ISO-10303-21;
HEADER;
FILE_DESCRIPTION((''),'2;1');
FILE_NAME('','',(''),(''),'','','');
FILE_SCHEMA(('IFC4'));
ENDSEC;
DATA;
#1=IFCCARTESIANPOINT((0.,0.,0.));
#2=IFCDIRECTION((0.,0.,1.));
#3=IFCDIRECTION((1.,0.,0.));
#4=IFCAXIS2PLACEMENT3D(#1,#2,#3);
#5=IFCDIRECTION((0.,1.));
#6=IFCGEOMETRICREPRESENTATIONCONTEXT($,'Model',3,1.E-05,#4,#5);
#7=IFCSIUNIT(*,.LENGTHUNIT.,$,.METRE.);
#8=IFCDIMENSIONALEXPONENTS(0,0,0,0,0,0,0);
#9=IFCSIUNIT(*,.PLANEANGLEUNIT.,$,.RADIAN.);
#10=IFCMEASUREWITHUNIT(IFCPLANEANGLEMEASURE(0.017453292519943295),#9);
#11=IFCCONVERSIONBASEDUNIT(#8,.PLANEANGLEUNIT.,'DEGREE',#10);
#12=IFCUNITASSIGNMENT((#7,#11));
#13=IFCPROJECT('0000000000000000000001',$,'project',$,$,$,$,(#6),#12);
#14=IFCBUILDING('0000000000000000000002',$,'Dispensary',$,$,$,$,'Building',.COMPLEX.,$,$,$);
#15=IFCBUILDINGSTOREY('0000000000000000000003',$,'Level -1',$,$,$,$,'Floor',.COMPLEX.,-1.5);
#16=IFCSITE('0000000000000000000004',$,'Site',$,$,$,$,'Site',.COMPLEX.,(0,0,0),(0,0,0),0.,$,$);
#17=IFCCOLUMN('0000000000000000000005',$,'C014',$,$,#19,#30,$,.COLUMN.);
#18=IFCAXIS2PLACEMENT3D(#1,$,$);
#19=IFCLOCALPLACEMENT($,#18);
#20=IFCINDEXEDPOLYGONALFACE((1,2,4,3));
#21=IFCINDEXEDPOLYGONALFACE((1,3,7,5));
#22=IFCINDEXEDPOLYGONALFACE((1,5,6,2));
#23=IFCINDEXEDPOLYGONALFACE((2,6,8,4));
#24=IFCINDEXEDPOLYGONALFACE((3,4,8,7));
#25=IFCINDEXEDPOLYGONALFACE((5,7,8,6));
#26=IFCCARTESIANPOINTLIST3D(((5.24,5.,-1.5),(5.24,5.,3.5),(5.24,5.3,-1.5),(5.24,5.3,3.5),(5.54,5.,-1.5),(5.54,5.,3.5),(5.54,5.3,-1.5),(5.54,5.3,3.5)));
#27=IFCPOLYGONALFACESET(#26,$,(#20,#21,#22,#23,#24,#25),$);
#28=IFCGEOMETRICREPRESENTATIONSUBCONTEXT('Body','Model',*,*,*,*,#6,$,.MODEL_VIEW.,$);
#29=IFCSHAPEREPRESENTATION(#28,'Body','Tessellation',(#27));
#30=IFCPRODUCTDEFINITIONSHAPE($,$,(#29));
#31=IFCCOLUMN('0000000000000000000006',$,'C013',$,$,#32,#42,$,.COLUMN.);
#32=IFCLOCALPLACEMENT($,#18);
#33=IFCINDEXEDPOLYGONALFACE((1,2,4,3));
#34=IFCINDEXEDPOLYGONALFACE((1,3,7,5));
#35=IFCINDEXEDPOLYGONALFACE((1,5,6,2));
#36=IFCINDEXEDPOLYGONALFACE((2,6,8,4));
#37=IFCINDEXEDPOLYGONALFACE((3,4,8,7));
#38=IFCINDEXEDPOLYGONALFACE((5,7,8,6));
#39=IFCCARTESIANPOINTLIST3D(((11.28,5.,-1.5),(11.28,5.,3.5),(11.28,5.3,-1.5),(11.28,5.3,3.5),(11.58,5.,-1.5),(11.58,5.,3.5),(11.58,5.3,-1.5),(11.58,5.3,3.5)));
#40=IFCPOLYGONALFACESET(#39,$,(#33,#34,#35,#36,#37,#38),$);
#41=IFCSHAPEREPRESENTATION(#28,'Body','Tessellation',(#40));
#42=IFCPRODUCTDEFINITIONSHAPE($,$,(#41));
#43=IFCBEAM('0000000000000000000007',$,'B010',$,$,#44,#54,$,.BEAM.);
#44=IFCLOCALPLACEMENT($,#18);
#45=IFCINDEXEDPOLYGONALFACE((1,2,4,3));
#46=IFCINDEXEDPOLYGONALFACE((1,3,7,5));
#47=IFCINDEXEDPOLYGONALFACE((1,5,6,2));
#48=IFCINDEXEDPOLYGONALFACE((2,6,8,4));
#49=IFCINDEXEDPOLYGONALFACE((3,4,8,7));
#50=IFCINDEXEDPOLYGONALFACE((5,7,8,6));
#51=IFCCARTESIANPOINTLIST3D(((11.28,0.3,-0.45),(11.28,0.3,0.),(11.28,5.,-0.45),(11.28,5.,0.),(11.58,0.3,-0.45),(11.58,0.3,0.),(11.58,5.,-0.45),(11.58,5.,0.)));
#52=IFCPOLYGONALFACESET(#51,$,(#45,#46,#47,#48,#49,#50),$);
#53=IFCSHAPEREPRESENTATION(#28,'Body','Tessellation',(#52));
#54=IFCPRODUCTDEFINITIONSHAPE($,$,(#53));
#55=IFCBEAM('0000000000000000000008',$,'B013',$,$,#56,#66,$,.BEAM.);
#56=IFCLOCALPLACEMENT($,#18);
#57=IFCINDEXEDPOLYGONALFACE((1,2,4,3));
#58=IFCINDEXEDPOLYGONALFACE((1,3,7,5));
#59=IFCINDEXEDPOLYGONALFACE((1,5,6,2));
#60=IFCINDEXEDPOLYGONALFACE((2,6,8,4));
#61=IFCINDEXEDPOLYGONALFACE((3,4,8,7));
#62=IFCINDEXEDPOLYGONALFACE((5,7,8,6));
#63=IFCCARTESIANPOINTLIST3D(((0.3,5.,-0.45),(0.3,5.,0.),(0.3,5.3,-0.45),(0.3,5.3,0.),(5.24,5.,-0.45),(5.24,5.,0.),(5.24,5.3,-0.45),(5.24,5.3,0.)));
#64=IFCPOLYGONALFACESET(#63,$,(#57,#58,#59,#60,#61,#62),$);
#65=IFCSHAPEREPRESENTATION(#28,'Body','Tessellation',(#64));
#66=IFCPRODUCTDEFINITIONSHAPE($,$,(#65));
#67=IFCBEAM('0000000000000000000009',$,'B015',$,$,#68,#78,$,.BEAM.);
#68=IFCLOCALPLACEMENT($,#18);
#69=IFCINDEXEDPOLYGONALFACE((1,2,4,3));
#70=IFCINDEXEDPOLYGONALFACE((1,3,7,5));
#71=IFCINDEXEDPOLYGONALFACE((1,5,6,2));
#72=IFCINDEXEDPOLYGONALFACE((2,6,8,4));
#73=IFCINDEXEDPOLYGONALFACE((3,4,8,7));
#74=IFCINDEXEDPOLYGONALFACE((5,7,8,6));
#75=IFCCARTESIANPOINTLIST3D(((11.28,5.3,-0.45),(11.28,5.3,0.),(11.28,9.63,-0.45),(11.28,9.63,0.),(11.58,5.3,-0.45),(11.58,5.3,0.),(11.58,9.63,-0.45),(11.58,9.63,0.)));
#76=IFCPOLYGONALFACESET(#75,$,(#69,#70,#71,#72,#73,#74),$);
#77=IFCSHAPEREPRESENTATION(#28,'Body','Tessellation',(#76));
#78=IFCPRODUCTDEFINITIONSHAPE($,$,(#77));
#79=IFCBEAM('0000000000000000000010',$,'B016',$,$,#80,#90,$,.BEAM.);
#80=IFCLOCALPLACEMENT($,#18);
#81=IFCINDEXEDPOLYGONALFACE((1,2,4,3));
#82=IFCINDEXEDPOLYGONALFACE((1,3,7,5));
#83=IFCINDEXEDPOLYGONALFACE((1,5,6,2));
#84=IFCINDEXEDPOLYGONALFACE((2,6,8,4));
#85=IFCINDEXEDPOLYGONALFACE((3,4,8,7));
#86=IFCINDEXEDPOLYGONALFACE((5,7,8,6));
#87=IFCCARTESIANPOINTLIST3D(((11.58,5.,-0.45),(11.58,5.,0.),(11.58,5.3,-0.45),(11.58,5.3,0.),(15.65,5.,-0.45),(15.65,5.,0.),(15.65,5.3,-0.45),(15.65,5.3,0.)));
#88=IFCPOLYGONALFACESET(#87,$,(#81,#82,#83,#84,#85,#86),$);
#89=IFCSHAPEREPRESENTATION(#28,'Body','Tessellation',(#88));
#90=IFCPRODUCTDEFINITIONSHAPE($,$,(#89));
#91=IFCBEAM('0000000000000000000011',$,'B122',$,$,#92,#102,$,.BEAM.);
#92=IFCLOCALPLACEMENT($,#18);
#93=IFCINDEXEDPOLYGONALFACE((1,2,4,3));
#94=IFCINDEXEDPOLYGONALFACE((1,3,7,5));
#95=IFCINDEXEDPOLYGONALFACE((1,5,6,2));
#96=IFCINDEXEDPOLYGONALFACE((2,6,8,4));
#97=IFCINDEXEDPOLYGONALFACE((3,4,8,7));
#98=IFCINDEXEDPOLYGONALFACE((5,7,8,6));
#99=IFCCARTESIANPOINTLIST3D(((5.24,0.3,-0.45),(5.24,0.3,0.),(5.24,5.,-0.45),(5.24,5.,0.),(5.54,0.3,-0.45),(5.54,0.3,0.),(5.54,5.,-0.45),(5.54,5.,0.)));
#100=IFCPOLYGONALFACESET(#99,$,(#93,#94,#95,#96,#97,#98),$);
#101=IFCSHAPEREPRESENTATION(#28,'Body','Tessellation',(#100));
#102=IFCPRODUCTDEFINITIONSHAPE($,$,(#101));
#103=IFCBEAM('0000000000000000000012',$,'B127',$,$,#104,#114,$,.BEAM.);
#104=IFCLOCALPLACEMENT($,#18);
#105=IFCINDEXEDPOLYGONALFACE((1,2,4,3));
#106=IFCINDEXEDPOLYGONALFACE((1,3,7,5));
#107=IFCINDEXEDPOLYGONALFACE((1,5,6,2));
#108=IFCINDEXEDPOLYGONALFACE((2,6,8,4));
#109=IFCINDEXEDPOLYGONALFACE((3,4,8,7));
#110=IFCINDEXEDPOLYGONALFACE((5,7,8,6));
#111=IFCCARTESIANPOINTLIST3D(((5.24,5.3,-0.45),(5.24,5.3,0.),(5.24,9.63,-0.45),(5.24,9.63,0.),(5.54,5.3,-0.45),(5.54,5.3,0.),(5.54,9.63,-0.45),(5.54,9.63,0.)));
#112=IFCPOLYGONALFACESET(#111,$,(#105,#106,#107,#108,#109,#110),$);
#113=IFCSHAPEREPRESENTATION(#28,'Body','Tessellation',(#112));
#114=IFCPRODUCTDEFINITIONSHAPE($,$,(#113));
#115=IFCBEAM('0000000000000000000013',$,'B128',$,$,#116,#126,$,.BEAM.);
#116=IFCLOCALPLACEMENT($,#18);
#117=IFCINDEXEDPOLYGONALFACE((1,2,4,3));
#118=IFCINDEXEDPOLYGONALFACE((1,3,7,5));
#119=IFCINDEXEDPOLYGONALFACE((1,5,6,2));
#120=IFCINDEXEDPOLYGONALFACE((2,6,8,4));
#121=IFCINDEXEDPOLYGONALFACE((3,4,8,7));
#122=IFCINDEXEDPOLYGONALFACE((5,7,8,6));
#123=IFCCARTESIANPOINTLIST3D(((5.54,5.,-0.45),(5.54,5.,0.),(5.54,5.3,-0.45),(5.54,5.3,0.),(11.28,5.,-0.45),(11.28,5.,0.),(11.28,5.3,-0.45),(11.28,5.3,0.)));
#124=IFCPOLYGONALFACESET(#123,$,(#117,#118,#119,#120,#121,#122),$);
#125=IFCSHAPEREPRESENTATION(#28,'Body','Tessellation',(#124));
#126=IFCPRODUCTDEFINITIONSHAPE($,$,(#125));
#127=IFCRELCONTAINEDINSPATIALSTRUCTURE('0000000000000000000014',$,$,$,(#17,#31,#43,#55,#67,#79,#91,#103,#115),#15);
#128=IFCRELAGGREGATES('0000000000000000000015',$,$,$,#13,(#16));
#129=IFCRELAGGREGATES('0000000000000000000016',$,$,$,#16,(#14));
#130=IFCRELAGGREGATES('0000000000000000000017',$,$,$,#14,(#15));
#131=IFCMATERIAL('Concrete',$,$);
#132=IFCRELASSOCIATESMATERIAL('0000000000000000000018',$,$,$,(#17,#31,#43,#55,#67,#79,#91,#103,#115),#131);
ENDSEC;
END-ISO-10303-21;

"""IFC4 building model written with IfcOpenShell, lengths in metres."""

from ifc_helpers import new_model, entity, si_unit, converted_unit, direction, frame, frame_2d, origin_with_axes, place, context, subcontext, project, spatial, rectangle, extrude, material, element, save


model = new_model("IFC4")

# Units and contexts
model_context = context("Model", 3, precision=1e-05, world=origin_with_axes(), true_north=direction((0.0, 1.0)))
body_context = subcontext(model_context, "Body", "Model", "MODEL_VIEW")
ifc_project = project(units=[si_unit("LENGTHUNIT", "METRE"), converted_unit("PLANEANGLEUNIT", "DEGREE", entity("IfcPlaneAngleMeasure", 0.017453292519943295), si_unit("PLANEANGLEUNIT", "RADIAN"), dimensions=[0, 0, 0, 0, 0, 0, 0])], contexts=[model_context])

# Site, building, storey
site = spatial("IfcSite", under=ifc_project, Name="Site", LongName="Site", CompositionType="COMPLEX", RefLatitude=(0, 0, 0), RefLongitude=(0, 0, 0), RefElevation=0.0)
building = spatial("IfcBuilding", under=site, Name="Dispensary", LongName="Building", CompositionType="COMPLEX")
storey = spatial("IfcBuildingStorey", under=building, Name="Level -1", LongName="Floor", CompositionType="COMPLEX", Elevation=-1.5)

# Columns
ifc_material_1 = material(Name="Concrete")
placement = place(None, origin_with_axes())
element("IfcColumn", 1, at=placement, inside=storey, material=ifc_material_1, Name="C014", PredefinedType="COLUMN", context=body_context, shape_type="SweptSolid", body=[
    extrude(rectangle(XDim=0.3, YDim=0.3, at=frame_2d((0.0, 0.0), x_axis=(1.0, 0.0))), frame((5.39, 5.15, -1.5), z_axis=(0.0, 0.0, 1.0), x_axis=(1.0, 0.0, 0.0)), (0.0, 0.0, 1.0), 5.0),
])
element("IfcColumn", 2, at=placement, inside=storey, material=ifc_material_1, Name="C013", PredefinedType="COLUMN", context=body_context, shape_type="SweptSolid", body=[
    extrude(rectangle(XDim=0.3, YDim=0.3, at=frame_2d((0.0, 0.0), x_axis=(1.0, 0.0))), frame((11.43, 5.15, -1.5), z_axis=(0.0, 0.0, 1.0), x_axis=(1.0, 0.0, 0.0)), (0.0, 0.0, 1.0), 5.0),
])

# Beams
element("IfcBeam", 3, at=placement, inside=storey, material=ifc_material_1, Name="B010", PredefinedType="BEAM", context=body_context, shape_type="SweptSolid", body=[
    extrude(rectangle(XDim=0.3, YDim=0.45, at=frame_2d((0.0, 0.0), x_axis=(0.0, 1.0))), frame((11.43, 0.3, -0.225), z_axis=(0.0, 1.0, 0.0), x_axis=(0.0, 0.0, -1.0)), (0.0, 0.0, 1.0), 4.7),
])
element("IfcBeam", 4, at=placement, inside=storey, material=ifc_material_1, Name="B013", PredefinedType="BEAM", context=body_context, shape_type="SweptSolid", body=[
    extrude(rectangle(XDim=0.3, YDim=0.45, at=frame_2d((0.0, 0.0), x_axis=(0.0, 1.0))), frame((0.3, 5.15, -0.225), z_axis=(1.0, 0.0, 0.0), x_axis=(0.0, 0.0, -1.0)), (0.0, 0.0, 1.0), 4.94),
])
element("IfcBeam", 5, at=placement, inside=storey, material=ifc_material_1, Name="B015", PredefinedType="BEAM", context=body_context, shape_type="SweptSolid", body=[
    extrude(rectangle(XDim=0.3, YDim=0.45, at=frame_2d((0.0, 0.0), x_axis=(0.0, 1.0))), frame((11.43, 9.63, -0.225), z_axis=(0.0, -1.0, 0.0), x_axis=(0.0, 0.0, -1.0)), (0.0, 0.0, 1.0), 4.33),
])
element("IfcBeam", 6, at=placement, inside=storey, material=ifc_material_1, Name="B016", PredefinedType="BEAM", context=body_context, shape_type="SweptSolid", body=[
    extrude(rectangle(XDim=0.3, YDim=0.45, at=frame_2d((0.0, 0.0), x_axis=(0.0, 1.0))), frame((11.58, 5.15, -0.225), z_axis=(1.0, 0.0, 0.0), x_axis=(0.0, 0.0, -1.0)), (0.0, 0.0, 1.0), 4.07),
])
element("IfcBeam", 7, at=placement, inside=storey, material=ifc_material_1, Name="B122", PredefinedType="BEAM", context=body_context, shape_type="SweptSolid", body=[
    extrude(rectangle(XDim=0.3, YDim=0.45, at=frame_2d((0.0, 0.0), x_axis=(0.0, 1.0))), frame((5.39, 0.3, -0.225), z_axis=(0.0, 1.0, 0.0), x_axis=(0.0, 0.0, -1.0)), (0.0, 0.0, 1.0), 4.7),
])
element("IfcBeam", 8, at=placement, inside=storey, material=ifc_material_1, Name="B127", PredefinedType="BEAM", context=body_context, shape_type="SweptSolid", body=[
    extrude(rectangle(XDim=0.3, YDim=0.45, at=frame_2d((0.0, 0.0), x_axis=(0.0, 1.0))), frame((5.39, 9.63, -0.225), z_axis=(0.0, -1.0, 0.0), x_axis=(0.0, 0.0, -1.0)), (0.0, 0.0, 1.0), 4.33),
])
element("IfcBeam", 9, at=placement, inside=storey, material=ifc_material_1, Name="B128", PredefinedType="BEAM", context=body_context, shape_type="SweptSolid", body=[
    extrude(rectangle(XDim=0.3, YDim=0.45, at=frame_2d((0.0, 0.0), x_axis=(0.0, 1.0))), frame((5.54, 5.15, -0.225), z_axis=(1.0, 0.0, 0.0), x_axis=(0.0, 0.0, -1.0)), (0.0, 0.0, 1.0), 5.74),
])

save(model, "model.ifc")
